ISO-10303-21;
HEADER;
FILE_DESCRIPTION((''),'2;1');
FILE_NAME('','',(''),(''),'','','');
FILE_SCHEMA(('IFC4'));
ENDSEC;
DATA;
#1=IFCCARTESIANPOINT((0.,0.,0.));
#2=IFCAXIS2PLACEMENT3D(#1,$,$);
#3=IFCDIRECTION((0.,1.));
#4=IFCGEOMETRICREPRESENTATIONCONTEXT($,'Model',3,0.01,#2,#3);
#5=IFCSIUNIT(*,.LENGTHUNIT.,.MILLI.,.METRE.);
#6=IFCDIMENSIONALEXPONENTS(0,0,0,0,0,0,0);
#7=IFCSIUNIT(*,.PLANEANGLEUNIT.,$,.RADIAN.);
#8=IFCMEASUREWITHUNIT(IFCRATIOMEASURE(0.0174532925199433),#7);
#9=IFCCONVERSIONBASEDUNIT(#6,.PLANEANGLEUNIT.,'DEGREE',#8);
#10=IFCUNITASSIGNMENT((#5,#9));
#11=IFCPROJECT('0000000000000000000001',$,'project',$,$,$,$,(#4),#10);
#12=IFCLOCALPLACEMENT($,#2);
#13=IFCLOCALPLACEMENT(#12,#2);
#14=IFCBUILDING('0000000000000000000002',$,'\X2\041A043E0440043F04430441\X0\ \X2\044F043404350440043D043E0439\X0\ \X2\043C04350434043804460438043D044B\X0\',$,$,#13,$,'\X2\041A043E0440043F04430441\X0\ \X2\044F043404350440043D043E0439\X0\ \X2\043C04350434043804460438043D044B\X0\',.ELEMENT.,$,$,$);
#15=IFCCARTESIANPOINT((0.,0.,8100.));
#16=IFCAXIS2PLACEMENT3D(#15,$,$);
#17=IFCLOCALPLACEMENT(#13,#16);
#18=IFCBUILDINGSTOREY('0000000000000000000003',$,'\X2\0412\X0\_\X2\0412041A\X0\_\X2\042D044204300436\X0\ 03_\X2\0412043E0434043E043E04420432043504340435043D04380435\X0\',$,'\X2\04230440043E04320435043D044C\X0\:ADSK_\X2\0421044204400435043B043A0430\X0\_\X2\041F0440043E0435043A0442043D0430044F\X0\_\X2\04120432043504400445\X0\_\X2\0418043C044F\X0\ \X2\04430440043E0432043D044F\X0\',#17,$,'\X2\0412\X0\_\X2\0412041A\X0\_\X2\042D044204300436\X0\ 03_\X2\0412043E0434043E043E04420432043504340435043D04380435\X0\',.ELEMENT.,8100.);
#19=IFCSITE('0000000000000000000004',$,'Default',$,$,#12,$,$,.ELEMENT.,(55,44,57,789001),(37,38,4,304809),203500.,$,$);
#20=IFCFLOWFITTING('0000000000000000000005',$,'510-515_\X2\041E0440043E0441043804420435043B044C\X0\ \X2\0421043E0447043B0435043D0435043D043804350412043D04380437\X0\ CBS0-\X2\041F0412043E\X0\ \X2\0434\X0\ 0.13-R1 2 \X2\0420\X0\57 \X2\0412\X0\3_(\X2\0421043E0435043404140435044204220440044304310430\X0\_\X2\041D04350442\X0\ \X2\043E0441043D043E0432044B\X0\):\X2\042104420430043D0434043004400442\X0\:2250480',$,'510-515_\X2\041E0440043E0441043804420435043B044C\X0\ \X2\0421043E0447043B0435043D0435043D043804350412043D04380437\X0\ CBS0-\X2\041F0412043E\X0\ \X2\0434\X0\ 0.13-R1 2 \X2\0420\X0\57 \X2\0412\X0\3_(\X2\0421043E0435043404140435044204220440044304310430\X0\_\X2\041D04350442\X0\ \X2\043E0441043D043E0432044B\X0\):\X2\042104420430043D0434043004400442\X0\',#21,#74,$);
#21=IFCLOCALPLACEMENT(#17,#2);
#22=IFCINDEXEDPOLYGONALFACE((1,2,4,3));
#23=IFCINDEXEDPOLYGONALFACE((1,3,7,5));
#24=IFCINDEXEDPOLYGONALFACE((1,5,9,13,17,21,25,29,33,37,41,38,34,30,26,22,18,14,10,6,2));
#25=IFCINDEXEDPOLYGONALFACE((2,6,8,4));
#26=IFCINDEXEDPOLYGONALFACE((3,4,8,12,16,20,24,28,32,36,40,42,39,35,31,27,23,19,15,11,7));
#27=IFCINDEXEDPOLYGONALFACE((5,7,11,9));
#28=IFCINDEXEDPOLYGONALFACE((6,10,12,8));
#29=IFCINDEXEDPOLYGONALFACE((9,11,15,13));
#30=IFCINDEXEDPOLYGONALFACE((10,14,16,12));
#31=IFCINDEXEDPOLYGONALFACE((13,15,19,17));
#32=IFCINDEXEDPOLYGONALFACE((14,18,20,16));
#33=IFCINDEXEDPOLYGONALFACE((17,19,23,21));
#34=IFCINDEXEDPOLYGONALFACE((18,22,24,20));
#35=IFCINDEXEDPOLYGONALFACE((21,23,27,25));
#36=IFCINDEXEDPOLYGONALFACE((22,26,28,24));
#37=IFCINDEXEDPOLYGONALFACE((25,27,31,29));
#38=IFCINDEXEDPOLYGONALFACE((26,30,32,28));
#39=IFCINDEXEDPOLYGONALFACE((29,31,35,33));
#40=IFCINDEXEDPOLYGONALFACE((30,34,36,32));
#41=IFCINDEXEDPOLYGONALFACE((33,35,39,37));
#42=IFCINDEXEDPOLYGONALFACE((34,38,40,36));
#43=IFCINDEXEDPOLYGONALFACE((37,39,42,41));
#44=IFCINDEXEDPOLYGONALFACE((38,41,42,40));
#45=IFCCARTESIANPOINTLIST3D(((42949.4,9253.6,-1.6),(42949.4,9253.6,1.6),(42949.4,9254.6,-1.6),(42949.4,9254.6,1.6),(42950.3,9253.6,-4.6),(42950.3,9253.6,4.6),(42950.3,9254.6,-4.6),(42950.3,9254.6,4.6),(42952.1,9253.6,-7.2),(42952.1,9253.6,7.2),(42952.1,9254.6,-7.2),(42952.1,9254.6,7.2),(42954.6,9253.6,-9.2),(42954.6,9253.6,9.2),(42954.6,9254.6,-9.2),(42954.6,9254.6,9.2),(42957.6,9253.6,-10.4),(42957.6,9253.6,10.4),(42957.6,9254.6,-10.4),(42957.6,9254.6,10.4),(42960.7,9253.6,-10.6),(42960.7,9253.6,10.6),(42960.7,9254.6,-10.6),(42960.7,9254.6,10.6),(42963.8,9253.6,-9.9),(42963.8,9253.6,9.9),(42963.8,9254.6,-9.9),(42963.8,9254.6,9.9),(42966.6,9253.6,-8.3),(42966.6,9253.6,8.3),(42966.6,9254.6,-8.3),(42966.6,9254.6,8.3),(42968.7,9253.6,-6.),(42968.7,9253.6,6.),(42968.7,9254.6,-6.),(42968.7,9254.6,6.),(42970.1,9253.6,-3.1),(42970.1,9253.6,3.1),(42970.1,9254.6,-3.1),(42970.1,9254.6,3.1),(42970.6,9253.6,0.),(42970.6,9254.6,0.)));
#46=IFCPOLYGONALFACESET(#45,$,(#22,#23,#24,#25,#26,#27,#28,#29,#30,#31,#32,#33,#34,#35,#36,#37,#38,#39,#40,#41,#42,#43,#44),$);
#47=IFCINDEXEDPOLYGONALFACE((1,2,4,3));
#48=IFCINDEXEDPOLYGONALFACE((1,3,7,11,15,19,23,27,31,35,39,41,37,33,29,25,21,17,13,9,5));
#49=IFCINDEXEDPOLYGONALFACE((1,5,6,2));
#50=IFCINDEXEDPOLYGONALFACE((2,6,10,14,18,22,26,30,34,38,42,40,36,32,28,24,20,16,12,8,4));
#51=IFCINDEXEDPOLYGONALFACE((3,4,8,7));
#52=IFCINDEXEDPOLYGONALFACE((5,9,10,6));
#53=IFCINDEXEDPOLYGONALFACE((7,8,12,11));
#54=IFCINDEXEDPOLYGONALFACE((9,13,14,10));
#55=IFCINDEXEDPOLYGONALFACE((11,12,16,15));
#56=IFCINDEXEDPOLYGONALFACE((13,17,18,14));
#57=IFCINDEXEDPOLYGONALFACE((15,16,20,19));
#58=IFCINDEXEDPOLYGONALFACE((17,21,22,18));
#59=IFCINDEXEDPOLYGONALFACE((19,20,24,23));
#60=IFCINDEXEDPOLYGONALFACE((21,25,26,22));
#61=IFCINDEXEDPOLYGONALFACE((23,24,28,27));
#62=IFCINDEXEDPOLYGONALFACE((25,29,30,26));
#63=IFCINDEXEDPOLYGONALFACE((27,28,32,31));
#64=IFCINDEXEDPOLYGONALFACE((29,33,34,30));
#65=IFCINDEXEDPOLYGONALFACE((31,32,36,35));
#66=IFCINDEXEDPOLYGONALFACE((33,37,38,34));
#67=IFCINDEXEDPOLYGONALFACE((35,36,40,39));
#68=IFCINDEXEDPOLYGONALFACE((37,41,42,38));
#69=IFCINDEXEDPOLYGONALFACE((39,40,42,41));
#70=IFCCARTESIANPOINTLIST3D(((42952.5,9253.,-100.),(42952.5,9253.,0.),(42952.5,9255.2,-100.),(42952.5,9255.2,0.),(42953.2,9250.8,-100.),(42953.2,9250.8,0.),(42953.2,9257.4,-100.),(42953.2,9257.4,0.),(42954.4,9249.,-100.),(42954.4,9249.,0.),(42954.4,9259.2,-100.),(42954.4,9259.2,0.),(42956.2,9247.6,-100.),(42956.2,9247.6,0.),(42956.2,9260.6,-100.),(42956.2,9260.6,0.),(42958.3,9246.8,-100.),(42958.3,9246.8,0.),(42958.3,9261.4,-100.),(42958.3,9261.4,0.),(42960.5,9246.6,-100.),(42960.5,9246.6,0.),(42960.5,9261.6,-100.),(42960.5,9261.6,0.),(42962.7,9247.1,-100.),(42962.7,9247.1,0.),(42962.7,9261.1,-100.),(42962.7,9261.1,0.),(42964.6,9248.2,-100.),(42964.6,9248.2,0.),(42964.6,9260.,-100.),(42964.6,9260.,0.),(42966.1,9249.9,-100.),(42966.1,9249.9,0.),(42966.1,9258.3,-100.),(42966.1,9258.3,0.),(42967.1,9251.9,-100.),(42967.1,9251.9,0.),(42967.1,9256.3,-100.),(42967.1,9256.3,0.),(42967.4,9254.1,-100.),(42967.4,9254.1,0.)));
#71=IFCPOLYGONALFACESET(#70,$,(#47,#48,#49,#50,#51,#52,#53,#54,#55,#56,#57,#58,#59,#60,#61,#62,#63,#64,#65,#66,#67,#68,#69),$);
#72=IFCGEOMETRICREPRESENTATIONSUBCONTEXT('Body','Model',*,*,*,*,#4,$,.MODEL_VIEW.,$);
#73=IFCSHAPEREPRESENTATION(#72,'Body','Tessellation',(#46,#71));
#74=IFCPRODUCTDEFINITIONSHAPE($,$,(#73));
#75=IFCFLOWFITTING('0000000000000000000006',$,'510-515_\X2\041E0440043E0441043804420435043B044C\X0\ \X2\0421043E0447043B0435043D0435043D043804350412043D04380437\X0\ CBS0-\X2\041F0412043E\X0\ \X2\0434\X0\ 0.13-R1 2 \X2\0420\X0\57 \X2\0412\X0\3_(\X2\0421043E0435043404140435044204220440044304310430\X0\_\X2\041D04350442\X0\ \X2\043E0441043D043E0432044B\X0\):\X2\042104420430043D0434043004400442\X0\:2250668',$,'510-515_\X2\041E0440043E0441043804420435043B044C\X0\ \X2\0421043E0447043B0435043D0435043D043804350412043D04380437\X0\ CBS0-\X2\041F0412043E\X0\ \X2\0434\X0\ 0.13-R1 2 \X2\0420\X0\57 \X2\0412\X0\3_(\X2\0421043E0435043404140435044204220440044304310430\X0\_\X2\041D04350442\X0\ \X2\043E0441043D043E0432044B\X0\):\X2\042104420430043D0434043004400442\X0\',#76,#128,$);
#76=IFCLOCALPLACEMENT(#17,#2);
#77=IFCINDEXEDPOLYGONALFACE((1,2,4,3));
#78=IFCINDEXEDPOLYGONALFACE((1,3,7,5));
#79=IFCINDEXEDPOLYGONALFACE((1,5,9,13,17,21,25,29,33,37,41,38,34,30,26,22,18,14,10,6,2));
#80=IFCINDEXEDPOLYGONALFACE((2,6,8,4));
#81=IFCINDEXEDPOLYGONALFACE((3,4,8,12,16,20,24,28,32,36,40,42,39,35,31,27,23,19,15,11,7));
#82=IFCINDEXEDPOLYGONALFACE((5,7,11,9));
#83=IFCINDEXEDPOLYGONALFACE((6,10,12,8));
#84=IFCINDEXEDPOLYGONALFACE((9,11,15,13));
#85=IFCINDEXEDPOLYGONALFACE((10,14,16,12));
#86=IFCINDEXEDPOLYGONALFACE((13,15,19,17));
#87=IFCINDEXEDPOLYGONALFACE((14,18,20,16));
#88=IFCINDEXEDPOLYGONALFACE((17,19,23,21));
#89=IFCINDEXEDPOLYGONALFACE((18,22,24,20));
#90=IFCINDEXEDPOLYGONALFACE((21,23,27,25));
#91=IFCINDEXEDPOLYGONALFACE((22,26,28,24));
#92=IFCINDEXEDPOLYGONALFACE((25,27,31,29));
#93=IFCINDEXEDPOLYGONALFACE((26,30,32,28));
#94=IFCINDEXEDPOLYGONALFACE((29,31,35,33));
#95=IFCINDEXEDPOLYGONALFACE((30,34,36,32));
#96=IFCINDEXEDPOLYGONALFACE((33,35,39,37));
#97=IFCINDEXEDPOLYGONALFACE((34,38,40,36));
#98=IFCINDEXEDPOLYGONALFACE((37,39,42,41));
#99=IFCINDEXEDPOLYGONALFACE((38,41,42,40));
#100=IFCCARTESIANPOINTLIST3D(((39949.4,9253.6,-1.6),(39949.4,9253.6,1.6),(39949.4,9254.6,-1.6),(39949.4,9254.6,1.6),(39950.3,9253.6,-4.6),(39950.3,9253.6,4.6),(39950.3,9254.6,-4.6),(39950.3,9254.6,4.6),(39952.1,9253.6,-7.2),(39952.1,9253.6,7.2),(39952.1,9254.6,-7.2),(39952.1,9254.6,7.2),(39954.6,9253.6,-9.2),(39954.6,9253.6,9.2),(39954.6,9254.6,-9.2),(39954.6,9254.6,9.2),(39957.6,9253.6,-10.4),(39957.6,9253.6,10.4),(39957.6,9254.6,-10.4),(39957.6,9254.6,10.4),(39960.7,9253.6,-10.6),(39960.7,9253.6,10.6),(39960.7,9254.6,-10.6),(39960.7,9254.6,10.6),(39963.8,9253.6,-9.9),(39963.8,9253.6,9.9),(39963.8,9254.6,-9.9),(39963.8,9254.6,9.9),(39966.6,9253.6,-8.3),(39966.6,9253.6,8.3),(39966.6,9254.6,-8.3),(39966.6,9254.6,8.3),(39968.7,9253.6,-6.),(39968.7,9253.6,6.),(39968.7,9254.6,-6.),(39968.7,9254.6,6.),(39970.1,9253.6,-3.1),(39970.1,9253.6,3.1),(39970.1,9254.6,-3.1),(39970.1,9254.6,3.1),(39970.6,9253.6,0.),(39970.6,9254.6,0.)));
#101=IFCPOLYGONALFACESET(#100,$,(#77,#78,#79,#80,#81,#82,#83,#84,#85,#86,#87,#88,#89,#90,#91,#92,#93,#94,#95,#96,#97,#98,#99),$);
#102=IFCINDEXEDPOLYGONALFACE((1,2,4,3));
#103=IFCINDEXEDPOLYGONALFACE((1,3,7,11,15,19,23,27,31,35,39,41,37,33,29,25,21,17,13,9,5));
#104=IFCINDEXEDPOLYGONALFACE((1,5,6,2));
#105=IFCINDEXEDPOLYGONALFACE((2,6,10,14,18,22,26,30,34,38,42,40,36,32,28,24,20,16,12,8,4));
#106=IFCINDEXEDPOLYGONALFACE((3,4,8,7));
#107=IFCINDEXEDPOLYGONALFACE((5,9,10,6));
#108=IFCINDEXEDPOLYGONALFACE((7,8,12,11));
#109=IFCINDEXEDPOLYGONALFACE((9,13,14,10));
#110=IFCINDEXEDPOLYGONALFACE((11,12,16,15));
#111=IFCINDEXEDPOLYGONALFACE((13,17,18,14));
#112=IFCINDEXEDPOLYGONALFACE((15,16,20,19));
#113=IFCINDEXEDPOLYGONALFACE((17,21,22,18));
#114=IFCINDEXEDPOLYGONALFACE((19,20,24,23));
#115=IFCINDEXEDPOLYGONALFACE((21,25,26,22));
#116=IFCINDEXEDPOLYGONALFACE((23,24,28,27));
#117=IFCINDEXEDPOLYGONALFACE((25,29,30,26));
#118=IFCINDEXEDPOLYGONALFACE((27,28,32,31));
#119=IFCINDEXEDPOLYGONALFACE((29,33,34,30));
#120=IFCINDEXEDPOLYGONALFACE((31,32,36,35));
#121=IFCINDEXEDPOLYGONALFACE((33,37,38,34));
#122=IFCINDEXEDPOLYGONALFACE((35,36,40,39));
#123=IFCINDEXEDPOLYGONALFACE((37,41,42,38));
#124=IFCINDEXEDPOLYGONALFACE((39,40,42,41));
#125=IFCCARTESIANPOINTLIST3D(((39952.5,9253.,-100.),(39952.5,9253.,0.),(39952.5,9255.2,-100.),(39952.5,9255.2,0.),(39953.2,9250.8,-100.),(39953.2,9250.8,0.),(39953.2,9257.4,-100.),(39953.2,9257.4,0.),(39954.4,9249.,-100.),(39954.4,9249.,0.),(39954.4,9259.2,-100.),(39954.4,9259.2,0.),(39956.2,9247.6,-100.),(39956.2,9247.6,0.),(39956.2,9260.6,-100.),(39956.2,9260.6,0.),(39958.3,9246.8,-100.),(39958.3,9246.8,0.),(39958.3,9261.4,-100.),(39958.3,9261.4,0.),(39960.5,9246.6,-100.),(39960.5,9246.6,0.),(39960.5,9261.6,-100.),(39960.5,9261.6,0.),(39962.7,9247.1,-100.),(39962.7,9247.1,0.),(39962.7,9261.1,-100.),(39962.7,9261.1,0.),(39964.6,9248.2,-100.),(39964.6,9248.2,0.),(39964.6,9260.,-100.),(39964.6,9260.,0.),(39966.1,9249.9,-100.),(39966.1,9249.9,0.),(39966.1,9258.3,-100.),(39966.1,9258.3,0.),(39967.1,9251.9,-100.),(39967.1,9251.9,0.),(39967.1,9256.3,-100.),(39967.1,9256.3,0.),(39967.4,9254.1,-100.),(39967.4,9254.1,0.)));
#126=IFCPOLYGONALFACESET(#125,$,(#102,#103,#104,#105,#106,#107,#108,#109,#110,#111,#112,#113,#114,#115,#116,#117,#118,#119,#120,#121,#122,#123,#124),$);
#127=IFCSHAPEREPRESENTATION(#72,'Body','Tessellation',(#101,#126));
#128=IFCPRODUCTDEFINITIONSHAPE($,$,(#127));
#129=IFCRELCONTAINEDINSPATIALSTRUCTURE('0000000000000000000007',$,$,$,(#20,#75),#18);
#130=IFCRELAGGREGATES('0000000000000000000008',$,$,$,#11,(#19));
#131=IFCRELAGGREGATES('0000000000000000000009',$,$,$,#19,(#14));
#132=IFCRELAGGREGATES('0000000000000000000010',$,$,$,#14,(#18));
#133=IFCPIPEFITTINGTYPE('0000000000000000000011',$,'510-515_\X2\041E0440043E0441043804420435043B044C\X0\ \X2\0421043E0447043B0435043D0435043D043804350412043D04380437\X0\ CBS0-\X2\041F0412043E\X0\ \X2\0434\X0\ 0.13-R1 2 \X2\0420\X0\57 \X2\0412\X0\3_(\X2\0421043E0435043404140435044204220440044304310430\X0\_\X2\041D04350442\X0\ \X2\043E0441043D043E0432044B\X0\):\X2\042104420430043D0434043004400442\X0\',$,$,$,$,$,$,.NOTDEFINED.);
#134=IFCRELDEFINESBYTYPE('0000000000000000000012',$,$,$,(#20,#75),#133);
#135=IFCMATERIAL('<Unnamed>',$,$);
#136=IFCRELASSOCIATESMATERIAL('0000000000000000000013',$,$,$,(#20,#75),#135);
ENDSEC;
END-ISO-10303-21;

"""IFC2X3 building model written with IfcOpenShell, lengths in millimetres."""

from ifc_helpers import new_model, entity, si_unit, converted_unit, direction, frame, origin, origin_2d_with_axis, place, context, subcontext, project, spatial, circle, extrude, source, transform, mapped, material, type_object, type_shapes, element, save


model = new_model("IFC2X3")

# Units and contexts
model_context = context("Model", 3, precision=0.01, world=origin(), true_north=direction((0.0, 1.0)))
body_context = subcontext(model_context, "Body", "Model", "MODEL_VIEW")
ifc_project = project(units=[si_unit("LENGTHUNIT", "METRE", prefix="MILLI"), converted_unit("PLANEANGLEUNIT", "DEGREE", entity("IfcRatioMeasure", 0.0174532925199433), si_unit("PLANEANGLEUNIT", "RADIAN"), dimensions=[0, 0, 0, 0, 0, 0, 0])], contexts=[model_context])

# Site, building, storey
site_placement = place(None, origin())
site = spatial("IfcSite", under=ifc_project, at=site_placement, Name="Default", CompositionType="ELEMENT", RefLatitude=(55, 44, 57, 789001), RefLongitude=(37, 38, 4, 304809), RefElevation=203500.0)
building_placement = place(site_placement, origin())
building = spatial("IfcBuilding", under=site, at=building_placement, Name="Корпус ядерной медицины", LongName="Корпус ядерной медицины", CompositionType="ELEMENT")
storey_placement = place(building_placement, frame((0.0, 0.0, 8100.0)))
storey = spatial("IfcBuildingStorey", under=building, at=storey_placement, Name="В_ВК_Этаж 03_Водоотведение", ObjectType="Уровень:ADSK_Стрелка_Проектная_Вверх_Имя уровня", LongName="В_ВК_Этаж 03_Водоотведение", CompositionType="ELEMENT", Elevation=8100.0)

# Flow fittings
ifc_material_1 = material(Name="<Unnamed>")
pipe_fitting_type = type_object("IfcPipeFittingType", Name="510-515_Ороситель СочленениеВниз CBS0-ПВо д 0.13-R1 2 Р57 В3_(СоедДетТруба_Нет основы):Стандарт", PredefinedType="NOTDEFINED")
shared_shape_1 = source(origin(), body_context, "Body", "SweptSolid", [
    extrude(circle(Radius=10.7, at=origin_2d_with_axis()), frame((-0.5, 0.0, 0.0), z_axis=(1.0, 0.0, 0.0), x_axis=(0.0, 1.0, 0.0)), (0.0, 0.0, 1.0), 1.0),
    extrude(circle(Radius=7.5, at=origin_2d_with_axis()), frame((0.0, 0.0, -100.0), z_axis=(0.0, 0.0, 1.0), x_axis=(0.0, 1.0, 0.0)), (0.0, 0.0, 1.0), 100.0),
])
type_shapes(pipe_fitting_type, [shared_shape_1])
for number, where, z_axis, x_axis, name in (
    (1, (42959.9, 9254.1, 0.0), (0.0, 0.0, 1.0), (0.0, -1.0, 0.0), "510-515_Ороситель СочленениеВниз CBS0-ПВо д 0.13-R1 2 Р57 В3_(СоедДетТруба_Нет основы):Стандарт:2250480"),
    (2, (39959.9, 9254.1, 0.0), (0.0, 0.0, 1.0), (0.0, -1.0, 0.0), "510-515_Ороситель СочленениеВниз CBS0-ПВо д 0.13-R1 2 Р57 В3_(СоедДетТруба_Нет основы):Стандарт:2250668"),
):
    element("IfcFlowFitting", number, at=place(storey_placement, frame(where, z_axis=z_axis, x_axis=x_axis)), inside=storey, type_object=pipe_fitting_type, material=ifc_material_1, Name=name, ObjectType="510-515_Ороситель СочленениеВниз CBS0-ПВо д 0.13-R1 2 Р57 В3_(СоедДетТруба_Нет основы):Стандарт", context=body_context, shape_type="MappedRepresentation", body=[
        mapped(shared_shape_1, transform((0.0, 0.0, 0.0), scale=1.0)),
    ])

save(model, "model.ifc")
